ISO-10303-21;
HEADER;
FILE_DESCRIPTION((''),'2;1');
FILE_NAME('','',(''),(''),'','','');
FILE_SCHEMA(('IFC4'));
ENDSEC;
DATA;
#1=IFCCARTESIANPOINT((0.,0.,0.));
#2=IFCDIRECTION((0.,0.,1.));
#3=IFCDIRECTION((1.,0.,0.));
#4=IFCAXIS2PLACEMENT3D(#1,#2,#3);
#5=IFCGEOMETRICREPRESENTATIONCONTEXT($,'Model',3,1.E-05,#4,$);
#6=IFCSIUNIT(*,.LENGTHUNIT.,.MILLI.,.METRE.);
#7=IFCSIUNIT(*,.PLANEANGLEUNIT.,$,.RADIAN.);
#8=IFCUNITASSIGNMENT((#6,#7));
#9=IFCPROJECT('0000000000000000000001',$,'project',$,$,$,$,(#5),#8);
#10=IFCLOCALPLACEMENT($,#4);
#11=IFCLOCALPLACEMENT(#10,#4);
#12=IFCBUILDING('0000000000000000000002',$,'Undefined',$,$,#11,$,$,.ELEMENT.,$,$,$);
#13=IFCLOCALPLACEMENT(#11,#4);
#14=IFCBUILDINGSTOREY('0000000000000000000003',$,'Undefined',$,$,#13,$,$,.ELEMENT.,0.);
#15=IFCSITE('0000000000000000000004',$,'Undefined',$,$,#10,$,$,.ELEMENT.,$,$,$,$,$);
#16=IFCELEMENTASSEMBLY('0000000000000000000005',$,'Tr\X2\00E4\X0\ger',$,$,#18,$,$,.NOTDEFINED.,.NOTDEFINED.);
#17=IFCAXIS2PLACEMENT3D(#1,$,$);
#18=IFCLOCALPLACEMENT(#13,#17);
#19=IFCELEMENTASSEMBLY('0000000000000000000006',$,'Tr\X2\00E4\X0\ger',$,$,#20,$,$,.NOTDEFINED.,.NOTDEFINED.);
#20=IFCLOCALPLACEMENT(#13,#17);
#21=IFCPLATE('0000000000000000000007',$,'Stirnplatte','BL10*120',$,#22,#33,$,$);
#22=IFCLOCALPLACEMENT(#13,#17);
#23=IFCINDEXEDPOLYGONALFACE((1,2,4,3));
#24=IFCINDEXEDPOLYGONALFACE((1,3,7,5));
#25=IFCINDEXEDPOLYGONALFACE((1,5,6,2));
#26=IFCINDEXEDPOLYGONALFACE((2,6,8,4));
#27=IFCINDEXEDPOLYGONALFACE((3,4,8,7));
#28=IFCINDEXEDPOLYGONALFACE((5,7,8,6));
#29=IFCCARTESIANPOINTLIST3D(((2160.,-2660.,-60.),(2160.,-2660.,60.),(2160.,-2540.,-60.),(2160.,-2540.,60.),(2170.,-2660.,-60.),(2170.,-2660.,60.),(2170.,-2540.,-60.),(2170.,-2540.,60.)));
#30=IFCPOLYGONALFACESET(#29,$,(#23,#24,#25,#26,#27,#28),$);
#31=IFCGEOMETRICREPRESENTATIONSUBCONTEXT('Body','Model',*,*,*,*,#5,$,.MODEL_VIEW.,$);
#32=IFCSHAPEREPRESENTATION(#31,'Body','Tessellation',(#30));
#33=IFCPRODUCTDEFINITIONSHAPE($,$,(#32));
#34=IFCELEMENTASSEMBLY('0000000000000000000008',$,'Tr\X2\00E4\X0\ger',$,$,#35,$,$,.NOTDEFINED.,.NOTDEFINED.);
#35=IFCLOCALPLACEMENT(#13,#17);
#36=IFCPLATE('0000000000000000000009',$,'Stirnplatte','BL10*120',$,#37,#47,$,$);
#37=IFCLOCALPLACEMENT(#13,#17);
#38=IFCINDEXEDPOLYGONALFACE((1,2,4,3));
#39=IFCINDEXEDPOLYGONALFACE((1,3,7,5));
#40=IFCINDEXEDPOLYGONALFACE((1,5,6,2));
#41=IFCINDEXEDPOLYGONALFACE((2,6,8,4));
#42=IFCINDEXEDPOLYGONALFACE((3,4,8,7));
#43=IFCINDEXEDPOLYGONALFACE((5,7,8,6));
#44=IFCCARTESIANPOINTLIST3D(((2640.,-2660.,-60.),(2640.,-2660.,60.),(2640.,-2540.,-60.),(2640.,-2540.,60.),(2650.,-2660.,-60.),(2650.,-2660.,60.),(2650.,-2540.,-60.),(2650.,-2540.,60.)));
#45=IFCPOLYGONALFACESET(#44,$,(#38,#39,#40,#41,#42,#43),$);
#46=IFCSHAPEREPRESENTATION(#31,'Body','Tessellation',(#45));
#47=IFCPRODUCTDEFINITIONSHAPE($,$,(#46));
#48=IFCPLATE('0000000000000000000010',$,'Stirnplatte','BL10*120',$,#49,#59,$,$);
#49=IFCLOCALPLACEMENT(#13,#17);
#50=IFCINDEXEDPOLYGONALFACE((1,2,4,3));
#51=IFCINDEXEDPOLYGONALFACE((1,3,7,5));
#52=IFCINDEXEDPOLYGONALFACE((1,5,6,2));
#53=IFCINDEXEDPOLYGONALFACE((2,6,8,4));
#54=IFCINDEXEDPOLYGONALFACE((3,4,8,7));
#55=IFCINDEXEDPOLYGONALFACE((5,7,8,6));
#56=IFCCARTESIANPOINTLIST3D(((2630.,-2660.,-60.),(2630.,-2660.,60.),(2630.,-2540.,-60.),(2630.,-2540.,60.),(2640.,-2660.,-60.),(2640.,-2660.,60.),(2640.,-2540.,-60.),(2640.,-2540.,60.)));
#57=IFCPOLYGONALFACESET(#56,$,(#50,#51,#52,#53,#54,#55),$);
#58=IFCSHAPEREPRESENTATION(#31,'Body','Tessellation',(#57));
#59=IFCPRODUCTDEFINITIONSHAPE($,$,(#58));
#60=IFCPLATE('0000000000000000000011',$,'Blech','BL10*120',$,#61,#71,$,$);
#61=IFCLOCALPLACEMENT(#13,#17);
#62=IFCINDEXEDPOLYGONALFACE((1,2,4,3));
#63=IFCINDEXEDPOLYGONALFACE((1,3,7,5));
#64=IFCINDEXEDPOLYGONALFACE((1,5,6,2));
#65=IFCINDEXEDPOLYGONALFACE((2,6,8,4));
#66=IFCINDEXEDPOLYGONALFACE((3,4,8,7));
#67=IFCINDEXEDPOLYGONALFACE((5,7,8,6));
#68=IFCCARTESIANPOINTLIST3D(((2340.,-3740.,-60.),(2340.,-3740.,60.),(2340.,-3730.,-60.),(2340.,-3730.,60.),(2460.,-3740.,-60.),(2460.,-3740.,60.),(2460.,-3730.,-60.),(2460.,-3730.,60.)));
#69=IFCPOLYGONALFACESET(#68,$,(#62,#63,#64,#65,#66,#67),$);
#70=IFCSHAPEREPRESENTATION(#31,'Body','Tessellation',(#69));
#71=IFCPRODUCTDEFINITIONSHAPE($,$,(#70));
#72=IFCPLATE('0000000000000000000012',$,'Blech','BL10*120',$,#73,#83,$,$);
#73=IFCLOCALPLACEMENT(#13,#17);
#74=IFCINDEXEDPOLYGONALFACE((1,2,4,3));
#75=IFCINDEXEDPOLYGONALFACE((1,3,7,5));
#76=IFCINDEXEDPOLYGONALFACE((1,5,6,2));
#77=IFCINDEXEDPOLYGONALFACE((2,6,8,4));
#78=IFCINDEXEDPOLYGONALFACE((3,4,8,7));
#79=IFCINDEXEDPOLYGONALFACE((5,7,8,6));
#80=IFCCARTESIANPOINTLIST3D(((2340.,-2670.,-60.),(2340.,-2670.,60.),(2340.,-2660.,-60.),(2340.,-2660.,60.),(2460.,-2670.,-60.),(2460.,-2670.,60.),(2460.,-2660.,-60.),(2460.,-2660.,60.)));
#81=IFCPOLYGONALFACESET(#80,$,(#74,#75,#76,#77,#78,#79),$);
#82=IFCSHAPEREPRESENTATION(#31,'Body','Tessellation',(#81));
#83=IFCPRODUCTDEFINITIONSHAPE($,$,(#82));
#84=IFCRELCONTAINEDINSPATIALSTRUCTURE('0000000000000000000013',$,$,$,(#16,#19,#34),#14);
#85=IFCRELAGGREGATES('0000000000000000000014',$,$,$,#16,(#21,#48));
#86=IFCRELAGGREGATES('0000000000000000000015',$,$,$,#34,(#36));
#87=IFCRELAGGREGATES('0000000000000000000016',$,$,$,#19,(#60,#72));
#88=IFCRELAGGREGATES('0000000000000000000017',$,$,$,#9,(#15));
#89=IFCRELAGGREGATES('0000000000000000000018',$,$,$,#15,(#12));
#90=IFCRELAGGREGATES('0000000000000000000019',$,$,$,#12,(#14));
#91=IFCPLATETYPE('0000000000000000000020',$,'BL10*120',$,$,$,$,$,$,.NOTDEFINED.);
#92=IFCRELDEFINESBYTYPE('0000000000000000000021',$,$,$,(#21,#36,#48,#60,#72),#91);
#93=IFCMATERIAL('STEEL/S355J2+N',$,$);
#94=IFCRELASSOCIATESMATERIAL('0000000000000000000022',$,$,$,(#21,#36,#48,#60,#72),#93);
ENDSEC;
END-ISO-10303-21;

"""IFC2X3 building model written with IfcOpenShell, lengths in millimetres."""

from ifc_helpers import new_model, si_unit, frame, origin_with_axes, place, context, subcontext, project, spatial, polyline, outline, extrude, material, type_object, element, aggregate, save


model = new_model("IFC2X3")

# Units and contexts
model_context = context("Model", 3, precision=1e-05, world=origin_with_axes())
body_context = subcontext(model_context, "Body", "Model", "MODEL_VIEW")
ifc_project = project(units=[si_unit("LENGTHUNIT", "METRE", prefix="MILLI"), si_unit("PLANEANGLEUNIT", "RADIAN")], contexts=[model_context])

# Site, building, storey
site_placement = place(None, origin_with_axes())
site = spatial("IfcSite", under=ifc_project, at=site_placement, Name="Undefined", CompositionType="ELEMENT")
building_placement = place(site_placement, origin_with_axes())
building = spatial("IfcBuilding", under=site, at=building_placement, Name="Undefined", CompositionType="ELEMENT")
storey_placement = place(building_placement, origin_with_axes())
storey = spatial("IfcBuildingStorey", under=building, at=storey_placement, Name="Undefined", CompositionType="ELEMENT", Elevation=0.0)

# Element assemblies
assembly_1_placement = place(storey_placement, origin_with_axes())
assembly_1 = element("IfcElementAssembly", 1, at=assembly_1_placement, inside=storey, Name="Träger", AssemblyPlace="NOTDEFINED", PredefinedType="NOTDEFINED")
assembly_2_placement = place(storey_placement, origin_with_axes())
assembly_2 = element("IfcElementAssembly", 2, at=assembly_2_placement, inside=storey, Name="Träger", AssemblyPlace="NOTDEFINED", PredefinedType="NOTDEFINED")

# Shared definitions
ifc_material_1 = material(Name="STEEL/S355J2+N")
plate_type = type_object("IfcPlateType", Name="BL10*120", PredefinedType="NOTDEFINED")

# Plate
plate_1_placement = place(assembly_1_placement, frame((2165.0, -2600.0, -60.0), z_axis=(-1.0, 0.0, 0.0), x_axis=(0.0, 0.0, 1.0)))
plate_1 = element("IfcPlate", 3, at=plate_1_placement, type_object=plate_type, material=ifc_material_1, Name="Stirnplatte", Description="BL10*120", context=body_context, shape_type="SweptSolid", body=[
    extrude(outline(polyline([(0.0, -60.0), (0.0, 60.0), (120.0, 60.0), (120.0, -60.0), (0.0, -60.0)])), frame((0.0, 0.0, -5.0), z_axis=(0.0, 0.0, 1.0), x_axis=(1.0, 0.0, 0.0)), (0.0, 0.0, 1.0), 10.0),
])

# Element assembly, plate
assembly_3_placement = place(storey_placement, origin_with_axes())
assembly_3 = element("IfcElementAssembly", 4, at=assembly_3_placement, inside=storey, Name="Träger", AssemblyPlace="NOTDEFINED", PredefinedType="NOTDEFINED")
plate_2_placement = place(assembly_3_placement, frame((2645.0, -2600.0, -60.0), z_axis=(1.0, 0.0, 0.0), x_axis=(0.0, 0.0, 1.0)))
plate_2 = element("IfcPlate", 5, at=plate_2_placement, type_object=plate_type, material=ifc_material_1, Name="Stirnplatte", Description="BL10*120", context=body_context, shape_type="SweptSolid", body=[
    extrude(outline(polyline([(0.0, -60.0), (0.0, 60.0), (120.0, 60.0), (120.0, -60.0), (0.0, -60.0)])), frame((0.0, 0.0, -5.0), z_axis=(0.0, 0.0, 1.0), x_axis=(1.0, 0.0, 0.0)), (0.0, 0.0, 1.0), 10.0),
])

# Plates
plate_3_placement = place(assembly_1_placement, frame((2635.0, -2600.0, -60.0), z_axis=(1.0, 0.0, 0.0), x_axis=(0.0, 0.0, 1.0)))
plate_3 = element("IfcPlate", 6, at=plate_3_placement, type_object=plate_type, material=ifc_material_1, Name="Stirnplatte", Description="BL10*120", context=body_context, shape_type="SweptSolid", body=[
    extrude(outline(polyline([(0.0, -60.0), (0.0, 60.0), (120.0, 60.0), (120.0, -60.0), (0.0, -60.0)])), frame((0.0, 0.0, -5.0), z_axis=(0.0, 0.0, 1.0), x_axis=(1.0, 0.0, 0.0)), (0.0, 0.0, 1.0), 10.0),
])
aggregate(assembly_1, [plate_1, plate_3])
plate_4_placement = place(assembly_2_placement, frame((2400.0, -3735.0, -60.0), z_axis=(0.0, 1.0, 0.0), x_axis=(0.0, 0.0, 1.0)))
plate_4 = element("IfcPlate", 7, at=plate_4_placement, type_object=plate_type, material=ifc_material_1, Name="Blech", Description="BL10*120", context=body_context, shape_type="SweptSolid", body=[
    extrude(outline(polyline([(0.0, -60.0), (0.0, 60.0), (120.0, 60.0), (120.0, -60.0), (0.0, -60.0)])), frame((0.0, 0.0, -5.0), z_axis=(0.0, 0.0, 1.0), x_axis=(1.0, 0.0, 0.0)), (0.0, 0.0, 1.0), 10.0),
])
plate_5_placement = place(assembly_2_placement, frame((2400.0, -2665.0, -60.0), z_axis=(0.0, -1.0, 0.0), x_axis=(0.0, 0.0, 1.0)))
plate_5 = element("IfcPlate", 8, at=plate_5_placement, type_object=plate_type, material=ifc_material_1, Name="Blech", Description="BL10*120", context=body_context, shape_type="SweptSolid", body=[
    extrude(outline(polyline([(0.0, -60.0), (0.0, 60.0), (120.0, 60.0), (120.0, -60.0), (0.0, -60.0)])), frame((0.0, 0.0, -5.0), z_axis=(0.0, 0.0, 1.0), x_axis=(1.0, 0.0, 0.0)), (0.0, 0.0, 1.0), 10.0),
])

aggregate(assembly_3, [plate_2])
aggregate(assembly_2, [plate_4, plate_5])

save(model, "model.ifc")
